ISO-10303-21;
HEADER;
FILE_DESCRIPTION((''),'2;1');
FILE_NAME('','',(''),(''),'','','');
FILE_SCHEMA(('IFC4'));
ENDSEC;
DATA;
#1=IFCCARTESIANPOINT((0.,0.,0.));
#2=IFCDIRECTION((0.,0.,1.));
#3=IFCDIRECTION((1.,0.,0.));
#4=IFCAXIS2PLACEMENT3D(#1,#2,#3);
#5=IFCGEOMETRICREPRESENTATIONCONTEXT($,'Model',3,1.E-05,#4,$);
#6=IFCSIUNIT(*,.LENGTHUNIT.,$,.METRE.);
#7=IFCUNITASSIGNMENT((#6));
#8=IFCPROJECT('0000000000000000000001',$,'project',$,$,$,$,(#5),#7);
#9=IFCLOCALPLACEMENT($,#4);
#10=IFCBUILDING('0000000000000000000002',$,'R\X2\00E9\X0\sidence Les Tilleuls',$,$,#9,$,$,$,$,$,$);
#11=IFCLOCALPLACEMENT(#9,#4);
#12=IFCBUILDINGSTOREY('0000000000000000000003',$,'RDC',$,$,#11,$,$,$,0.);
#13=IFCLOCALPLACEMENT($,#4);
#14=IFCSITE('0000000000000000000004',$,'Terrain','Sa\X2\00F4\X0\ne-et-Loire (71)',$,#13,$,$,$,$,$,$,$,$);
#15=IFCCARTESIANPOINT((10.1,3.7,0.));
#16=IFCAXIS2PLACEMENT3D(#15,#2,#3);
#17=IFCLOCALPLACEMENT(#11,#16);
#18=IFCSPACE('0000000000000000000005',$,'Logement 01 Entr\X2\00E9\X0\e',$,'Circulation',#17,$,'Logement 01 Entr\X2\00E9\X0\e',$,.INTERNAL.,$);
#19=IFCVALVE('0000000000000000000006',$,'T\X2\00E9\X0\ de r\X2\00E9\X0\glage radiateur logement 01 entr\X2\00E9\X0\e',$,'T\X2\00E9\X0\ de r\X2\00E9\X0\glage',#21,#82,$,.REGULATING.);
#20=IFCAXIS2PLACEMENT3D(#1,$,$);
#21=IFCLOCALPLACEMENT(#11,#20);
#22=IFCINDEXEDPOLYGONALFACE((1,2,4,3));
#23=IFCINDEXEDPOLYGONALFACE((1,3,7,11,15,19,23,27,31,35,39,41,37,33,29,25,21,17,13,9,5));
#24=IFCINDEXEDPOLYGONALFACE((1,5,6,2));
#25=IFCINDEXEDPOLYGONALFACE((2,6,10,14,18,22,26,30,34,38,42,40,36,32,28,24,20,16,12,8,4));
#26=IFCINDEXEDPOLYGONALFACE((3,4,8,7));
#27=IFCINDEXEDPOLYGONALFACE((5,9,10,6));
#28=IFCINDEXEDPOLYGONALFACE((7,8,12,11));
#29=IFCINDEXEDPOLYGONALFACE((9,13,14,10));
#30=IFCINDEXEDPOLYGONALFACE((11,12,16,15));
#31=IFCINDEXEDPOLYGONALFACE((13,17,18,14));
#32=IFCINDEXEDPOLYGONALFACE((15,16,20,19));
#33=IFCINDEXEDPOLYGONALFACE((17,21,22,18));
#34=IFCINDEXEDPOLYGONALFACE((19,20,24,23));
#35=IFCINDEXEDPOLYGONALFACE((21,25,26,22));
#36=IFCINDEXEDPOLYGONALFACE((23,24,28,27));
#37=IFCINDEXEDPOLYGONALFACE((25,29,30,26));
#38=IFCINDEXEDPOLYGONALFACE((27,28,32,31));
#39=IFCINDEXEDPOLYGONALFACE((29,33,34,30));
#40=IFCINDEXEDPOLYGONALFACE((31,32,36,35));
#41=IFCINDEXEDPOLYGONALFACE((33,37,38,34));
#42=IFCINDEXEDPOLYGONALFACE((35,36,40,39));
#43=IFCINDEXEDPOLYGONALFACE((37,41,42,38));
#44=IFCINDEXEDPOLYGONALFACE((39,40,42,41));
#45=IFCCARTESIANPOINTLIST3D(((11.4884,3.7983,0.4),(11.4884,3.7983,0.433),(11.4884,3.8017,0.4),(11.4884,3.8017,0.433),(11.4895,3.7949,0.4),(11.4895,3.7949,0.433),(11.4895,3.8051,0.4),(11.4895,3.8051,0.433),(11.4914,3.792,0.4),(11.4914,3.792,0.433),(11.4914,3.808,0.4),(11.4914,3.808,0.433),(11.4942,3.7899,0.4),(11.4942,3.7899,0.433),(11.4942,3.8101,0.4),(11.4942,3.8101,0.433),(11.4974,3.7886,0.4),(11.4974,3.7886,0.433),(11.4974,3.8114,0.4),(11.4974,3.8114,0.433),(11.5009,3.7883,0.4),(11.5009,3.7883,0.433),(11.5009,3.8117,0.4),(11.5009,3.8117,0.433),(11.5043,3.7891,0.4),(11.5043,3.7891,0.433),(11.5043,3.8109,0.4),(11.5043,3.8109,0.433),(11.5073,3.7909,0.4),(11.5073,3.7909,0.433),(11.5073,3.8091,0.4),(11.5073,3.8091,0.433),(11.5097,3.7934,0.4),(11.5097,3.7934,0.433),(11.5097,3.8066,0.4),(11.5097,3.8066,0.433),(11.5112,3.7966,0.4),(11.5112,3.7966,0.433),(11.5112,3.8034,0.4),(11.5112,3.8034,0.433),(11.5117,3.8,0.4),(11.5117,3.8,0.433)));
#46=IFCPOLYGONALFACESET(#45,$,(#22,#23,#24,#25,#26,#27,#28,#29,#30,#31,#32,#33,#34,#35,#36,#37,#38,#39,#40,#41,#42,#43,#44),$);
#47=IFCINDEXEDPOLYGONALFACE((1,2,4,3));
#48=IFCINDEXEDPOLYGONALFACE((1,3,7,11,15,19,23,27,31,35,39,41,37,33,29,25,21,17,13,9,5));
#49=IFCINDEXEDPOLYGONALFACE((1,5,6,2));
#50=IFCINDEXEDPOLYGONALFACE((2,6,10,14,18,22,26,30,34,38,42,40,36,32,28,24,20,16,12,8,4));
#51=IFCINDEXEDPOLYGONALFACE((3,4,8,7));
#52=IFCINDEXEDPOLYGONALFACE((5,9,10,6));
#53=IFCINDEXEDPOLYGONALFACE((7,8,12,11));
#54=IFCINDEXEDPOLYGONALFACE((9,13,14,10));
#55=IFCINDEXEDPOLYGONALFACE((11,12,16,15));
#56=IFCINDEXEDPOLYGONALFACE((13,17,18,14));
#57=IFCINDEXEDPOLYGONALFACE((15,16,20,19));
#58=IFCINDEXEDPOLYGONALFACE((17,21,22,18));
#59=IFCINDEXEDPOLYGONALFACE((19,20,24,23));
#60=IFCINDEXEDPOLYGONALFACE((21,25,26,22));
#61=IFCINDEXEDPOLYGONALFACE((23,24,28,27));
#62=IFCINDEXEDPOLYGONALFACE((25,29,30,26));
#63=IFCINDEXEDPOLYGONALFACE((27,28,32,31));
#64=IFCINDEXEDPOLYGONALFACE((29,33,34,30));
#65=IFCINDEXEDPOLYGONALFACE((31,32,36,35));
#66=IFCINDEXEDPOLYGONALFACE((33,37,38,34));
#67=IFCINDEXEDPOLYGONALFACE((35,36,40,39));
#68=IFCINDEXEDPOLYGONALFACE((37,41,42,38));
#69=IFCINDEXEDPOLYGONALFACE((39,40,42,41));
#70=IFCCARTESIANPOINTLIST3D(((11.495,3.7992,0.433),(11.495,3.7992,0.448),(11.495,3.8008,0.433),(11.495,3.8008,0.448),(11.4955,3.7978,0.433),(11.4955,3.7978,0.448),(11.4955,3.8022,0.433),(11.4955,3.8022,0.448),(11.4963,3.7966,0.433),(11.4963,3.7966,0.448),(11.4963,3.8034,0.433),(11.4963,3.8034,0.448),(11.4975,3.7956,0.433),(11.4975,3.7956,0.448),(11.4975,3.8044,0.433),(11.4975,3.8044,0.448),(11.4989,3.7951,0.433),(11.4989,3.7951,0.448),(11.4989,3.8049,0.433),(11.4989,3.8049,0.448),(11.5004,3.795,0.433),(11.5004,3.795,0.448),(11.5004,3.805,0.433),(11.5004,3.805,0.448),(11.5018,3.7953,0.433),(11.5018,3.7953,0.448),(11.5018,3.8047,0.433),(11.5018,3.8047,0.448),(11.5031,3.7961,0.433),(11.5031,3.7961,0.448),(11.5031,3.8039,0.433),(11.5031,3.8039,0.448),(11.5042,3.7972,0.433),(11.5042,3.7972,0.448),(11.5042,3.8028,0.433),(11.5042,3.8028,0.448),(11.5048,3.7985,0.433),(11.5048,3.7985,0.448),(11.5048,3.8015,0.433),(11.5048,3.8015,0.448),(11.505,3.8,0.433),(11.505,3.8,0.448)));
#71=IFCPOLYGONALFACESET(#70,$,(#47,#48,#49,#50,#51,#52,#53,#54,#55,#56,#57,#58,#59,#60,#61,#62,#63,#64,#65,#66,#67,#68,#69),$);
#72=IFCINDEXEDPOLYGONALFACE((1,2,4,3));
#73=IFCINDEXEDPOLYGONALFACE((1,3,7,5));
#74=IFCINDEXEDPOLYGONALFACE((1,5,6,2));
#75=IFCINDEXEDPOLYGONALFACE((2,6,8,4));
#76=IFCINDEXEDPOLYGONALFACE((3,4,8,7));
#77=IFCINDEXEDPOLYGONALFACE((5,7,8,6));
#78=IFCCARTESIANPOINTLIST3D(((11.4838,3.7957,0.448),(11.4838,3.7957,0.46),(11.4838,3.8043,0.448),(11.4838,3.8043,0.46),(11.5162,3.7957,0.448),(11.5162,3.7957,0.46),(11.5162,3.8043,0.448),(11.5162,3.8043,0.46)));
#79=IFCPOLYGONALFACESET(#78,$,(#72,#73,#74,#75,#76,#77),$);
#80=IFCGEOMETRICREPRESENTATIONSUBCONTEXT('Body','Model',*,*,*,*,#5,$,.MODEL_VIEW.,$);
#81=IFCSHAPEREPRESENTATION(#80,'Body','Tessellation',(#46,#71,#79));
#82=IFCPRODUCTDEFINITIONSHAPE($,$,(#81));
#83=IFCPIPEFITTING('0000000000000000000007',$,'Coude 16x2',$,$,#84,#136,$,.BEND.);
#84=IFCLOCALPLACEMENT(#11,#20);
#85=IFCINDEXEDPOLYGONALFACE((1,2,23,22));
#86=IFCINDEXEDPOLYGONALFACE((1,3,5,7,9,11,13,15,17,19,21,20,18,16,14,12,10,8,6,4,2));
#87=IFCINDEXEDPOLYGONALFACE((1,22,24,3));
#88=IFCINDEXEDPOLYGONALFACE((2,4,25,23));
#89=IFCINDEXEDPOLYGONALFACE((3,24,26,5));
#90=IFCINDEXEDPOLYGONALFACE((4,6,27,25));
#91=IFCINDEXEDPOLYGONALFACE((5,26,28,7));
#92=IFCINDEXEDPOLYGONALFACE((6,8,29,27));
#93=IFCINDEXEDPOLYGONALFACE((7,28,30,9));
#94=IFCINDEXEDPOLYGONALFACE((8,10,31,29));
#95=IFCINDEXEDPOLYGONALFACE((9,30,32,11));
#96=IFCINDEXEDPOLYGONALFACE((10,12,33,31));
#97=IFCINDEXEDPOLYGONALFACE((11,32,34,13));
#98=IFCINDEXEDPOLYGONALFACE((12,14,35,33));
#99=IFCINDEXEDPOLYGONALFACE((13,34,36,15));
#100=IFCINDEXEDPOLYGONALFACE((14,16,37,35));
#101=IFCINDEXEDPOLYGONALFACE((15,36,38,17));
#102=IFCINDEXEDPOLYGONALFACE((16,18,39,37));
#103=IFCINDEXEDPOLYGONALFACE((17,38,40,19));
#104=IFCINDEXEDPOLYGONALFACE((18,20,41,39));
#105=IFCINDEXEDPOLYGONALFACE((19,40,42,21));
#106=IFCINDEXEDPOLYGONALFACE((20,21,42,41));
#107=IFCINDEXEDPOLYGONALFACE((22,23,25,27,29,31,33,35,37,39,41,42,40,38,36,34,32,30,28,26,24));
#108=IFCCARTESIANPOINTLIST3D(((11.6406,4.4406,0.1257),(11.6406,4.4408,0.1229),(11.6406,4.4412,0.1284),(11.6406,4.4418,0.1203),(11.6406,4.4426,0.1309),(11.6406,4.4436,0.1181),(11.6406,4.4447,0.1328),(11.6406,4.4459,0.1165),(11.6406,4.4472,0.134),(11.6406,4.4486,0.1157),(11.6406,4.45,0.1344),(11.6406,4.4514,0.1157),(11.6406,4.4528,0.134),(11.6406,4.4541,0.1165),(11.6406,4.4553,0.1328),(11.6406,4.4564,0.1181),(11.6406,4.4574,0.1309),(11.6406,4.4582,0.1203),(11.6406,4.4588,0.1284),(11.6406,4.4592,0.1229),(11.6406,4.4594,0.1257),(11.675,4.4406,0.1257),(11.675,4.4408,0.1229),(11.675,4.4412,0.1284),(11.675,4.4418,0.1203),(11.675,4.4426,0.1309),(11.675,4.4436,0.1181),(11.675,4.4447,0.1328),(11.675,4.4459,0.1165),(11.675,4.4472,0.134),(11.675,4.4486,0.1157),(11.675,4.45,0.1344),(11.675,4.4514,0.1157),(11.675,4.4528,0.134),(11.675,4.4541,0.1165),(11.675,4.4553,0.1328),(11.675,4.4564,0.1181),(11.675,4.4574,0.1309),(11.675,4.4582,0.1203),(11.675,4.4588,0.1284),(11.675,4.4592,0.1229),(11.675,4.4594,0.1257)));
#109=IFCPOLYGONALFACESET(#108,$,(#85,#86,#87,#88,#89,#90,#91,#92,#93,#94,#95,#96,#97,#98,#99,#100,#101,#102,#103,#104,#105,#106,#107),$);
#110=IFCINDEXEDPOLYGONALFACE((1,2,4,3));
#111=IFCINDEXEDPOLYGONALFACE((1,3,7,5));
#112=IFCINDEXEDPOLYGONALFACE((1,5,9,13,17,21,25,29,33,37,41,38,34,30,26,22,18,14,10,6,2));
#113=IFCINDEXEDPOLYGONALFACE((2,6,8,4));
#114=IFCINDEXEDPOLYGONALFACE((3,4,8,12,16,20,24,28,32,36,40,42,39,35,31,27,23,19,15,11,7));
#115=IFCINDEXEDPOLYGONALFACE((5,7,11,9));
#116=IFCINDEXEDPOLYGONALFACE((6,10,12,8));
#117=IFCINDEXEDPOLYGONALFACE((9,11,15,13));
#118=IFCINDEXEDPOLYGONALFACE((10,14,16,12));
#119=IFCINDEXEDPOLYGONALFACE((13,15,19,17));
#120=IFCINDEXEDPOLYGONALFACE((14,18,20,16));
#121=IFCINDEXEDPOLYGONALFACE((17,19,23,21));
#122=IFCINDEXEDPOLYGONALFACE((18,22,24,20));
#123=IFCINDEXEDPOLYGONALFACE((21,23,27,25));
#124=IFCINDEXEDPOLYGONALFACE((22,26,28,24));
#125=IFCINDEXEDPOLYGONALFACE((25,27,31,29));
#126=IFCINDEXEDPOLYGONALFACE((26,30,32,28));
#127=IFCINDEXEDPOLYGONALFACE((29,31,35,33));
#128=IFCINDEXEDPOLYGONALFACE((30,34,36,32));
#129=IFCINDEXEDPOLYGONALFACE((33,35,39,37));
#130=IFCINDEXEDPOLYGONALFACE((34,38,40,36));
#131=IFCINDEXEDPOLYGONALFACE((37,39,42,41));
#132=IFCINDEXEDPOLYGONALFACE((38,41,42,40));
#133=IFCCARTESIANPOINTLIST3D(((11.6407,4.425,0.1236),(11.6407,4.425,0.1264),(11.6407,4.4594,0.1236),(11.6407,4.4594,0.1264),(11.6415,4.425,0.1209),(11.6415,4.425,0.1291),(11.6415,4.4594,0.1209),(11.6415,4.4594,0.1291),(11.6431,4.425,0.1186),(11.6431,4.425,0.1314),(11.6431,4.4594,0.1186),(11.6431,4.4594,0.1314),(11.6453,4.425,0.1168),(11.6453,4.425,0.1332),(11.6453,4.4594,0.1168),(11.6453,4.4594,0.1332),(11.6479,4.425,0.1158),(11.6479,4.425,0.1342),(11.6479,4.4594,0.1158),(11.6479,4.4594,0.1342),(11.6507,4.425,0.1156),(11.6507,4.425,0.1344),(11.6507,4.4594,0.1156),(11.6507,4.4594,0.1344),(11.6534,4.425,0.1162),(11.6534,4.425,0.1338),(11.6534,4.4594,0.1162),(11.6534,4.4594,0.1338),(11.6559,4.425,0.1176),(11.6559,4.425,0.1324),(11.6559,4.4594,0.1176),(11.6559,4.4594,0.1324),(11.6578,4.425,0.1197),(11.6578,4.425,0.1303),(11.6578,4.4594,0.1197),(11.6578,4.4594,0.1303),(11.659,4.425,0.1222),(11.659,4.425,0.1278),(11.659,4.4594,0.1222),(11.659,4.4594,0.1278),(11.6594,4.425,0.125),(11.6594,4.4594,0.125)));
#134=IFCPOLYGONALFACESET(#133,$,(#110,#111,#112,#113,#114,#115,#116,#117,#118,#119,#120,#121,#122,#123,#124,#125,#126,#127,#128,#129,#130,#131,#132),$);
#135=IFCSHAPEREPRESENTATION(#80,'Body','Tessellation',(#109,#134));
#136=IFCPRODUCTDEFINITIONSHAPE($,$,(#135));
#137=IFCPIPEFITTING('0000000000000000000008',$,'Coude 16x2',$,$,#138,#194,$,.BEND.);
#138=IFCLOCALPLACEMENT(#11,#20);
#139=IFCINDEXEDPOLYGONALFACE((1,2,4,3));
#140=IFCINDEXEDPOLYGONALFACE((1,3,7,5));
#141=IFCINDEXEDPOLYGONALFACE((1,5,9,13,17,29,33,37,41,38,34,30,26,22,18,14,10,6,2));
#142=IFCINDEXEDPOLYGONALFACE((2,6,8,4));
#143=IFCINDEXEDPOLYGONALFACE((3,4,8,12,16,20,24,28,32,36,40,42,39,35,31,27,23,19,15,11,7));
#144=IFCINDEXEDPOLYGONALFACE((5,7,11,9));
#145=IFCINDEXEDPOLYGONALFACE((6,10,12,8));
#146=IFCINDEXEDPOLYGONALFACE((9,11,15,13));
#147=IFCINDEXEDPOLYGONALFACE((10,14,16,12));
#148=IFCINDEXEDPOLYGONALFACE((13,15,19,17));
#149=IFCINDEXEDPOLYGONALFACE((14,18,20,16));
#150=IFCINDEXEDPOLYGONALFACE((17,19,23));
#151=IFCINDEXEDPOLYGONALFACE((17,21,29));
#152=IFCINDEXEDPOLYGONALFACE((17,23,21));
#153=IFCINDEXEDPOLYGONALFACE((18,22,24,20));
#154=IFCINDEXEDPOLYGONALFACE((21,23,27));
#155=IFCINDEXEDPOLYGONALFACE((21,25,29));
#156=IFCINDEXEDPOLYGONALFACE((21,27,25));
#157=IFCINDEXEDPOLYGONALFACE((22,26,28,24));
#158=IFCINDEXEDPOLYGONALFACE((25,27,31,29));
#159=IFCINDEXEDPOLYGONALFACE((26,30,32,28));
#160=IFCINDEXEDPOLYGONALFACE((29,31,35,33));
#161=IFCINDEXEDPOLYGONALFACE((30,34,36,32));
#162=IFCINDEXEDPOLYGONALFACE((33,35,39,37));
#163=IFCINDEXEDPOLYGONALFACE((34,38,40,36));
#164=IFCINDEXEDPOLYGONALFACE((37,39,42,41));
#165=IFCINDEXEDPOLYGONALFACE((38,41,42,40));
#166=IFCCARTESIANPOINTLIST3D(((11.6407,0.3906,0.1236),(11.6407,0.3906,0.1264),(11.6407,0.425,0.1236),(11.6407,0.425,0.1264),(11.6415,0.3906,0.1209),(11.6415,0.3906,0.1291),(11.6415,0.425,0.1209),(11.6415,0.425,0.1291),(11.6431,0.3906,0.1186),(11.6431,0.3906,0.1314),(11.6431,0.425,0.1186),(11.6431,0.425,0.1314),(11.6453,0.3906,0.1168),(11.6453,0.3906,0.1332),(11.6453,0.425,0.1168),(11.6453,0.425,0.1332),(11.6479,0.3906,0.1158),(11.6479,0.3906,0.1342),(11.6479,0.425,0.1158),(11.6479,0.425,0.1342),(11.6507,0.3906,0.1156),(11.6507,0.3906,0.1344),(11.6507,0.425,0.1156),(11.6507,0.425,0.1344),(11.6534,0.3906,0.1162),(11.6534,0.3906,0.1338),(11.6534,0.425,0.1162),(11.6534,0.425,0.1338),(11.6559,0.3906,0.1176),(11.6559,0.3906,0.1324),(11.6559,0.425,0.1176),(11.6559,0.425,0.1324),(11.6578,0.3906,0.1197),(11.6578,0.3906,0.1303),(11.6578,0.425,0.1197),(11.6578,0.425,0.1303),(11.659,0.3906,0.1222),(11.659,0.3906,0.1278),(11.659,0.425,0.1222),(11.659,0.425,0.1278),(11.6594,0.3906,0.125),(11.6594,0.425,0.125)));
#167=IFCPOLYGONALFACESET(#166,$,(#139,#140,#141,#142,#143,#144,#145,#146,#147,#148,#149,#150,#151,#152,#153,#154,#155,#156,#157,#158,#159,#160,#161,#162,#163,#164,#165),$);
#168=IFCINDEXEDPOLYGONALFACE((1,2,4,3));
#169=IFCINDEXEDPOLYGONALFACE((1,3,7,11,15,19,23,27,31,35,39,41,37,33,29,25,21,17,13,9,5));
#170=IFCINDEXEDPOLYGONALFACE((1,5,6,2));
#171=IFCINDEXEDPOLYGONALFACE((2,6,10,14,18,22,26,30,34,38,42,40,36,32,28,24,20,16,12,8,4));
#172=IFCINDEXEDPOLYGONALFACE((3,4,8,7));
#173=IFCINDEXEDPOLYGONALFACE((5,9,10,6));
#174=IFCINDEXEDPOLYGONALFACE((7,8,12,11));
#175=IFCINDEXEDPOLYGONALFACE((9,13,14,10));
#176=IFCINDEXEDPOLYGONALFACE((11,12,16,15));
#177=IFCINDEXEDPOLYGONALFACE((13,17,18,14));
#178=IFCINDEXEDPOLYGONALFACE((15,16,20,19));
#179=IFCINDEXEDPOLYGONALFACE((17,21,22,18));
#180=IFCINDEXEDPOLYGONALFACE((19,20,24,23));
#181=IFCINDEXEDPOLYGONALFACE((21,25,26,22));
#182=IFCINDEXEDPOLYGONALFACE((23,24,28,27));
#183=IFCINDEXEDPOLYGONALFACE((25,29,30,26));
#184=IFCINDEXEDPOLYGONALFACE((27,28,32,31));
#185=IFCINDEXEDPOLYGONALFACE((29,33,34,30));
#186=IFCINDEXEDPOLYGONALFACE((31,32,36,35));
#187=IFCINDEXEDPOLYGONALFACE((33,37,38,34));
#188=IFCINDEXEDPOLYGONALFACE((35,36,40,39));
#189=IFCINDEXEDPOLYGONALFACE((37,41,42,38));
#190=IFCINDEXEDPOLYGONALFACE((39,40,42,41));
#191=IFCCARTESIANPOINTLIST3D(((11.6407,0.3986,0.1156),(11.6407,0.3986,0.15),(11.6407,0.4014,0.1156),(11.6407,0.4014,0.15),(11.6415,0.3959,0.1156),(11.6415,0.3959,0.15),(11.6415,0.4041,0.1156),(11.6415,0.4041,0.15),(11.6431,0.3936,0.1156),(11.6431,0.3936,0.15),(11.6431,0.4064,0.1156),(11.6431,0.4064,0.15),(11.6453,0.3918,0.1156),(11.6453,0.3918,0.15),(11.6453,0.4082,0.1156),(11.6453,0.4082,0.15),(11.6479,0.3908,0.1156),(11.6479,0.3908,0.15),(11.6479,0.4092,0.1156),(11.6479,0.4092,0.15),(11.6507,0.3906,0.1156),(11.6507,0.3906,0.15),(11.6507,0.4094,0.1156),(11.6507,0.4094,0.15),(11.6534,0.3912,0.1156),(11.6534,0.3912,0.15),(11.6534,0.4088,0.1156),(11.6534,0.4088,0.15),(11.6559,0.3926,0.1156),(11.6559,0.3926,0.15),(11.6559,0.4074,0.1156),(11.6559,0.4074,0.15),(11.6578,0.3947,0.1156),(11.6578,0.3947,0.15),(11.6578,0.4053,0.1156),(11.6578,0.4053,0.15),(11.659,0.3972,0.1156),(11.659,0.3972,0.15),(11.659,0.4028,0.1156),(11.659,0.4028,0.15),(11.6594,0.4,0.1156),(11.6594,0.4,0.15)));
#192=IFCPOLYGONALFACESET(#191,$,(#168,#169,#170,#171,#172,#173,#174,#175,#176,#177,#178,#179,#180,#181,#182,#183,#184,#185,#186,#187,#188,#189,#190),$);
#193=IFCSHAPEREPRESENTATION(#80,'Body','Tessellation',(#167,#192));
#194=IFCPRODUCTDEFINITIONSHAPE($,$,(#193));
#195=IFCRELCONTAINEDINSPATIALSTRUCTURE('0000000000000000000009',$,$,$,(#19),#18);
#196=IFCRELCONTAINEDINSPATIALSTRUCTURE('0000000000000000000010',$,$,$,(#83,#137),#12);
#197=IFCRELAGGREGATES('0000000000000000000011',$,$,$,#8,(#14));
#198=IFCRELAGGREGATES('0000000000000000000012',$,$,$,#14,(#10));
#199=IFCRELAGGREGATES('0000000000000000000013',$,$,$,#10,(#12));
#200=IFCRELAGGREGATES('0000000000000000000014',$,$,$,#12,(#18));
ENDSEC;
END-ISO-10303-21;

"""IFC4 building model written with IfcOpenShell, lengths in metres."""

from ifc_helpers import new_model, si_unit, frame, frame_2d, origin_with_axes, place, context, subcontext, project, spatial, rectangle, circle, extrude, element, save


model = new_model("IFC4")

# Units and contexts
model_context = context("Model", 3, precision=1e-05, world=origin_with_axes())
body_context = subcontext(model_context, "Body", "Model", "MODEL_VIEW")
ifc_project = project(units=[si_unit("LENGTHUNIT", "METRE")], contexts=[model_context])

# Site, building, storey
site_placement = place(None, origin_with_axes())
site = spatial("IfcSite", under=ifc_project, at=site_placement, Name="Terrain", Description="Saône-et-Loire (71)")
building_placement = place(None, origin_with_axes())
building = spatial("IfcBuilding", under=site, at=building_placement, Name="Résidence Les Tilleuls")
storey_placement = place(building_placement, origin_with_axes())
storey = spatial("IfcBuildingStorey", under=building, at=storey_placement, Name="RDC", Elevation=0.0)

# Shared definitions
space_1_placement = place(storey_placement, frame((10.1, 3.7, 0.0), z_axis=(0.0, 0.0, 1.0), x_axis=(1.0, 0.0, 0.0)))
space_1 = spatial("IfcSpace", under=storey, at=space_1_placement, Name="Logement 01 Entrée", ObjectType="Circulation", LongName="Logement 01 Entrée", PredefinedType="INTERNAL")

# Valve
valve_1_placement = place(space_1_placement, frame((1.4, 0.1, 0.4), z_axis=(0.0, 0.0, 1.0), x_axis=(1.0, 0.0, 0.0)))
element("IfcValve", 1, at=valve_1_placement, inside=space_1, Name="Té de réglage radiateur logement 01 entrée", ObjectType="Té de réglage", PredefinedType="REGULATING", context=body_context, shape_type="SweptSolid", body=[
    extrude(circle(Radius=0.0117), origin_with_axes(), (0.0, 0.0, 1.0), 0.033),
    extrude(circle(Radius=0.005), frame((0.0, 0.0, 0.033), z_axis=(0.0, 0.0, 1.0), x_axis=(1.0, 0.0, 0.0)), (0.0, 0.0, 1.0), 0.015),
    extrude(rectangle(XDim=0.0324, YDim=0.0086, at=frame_2d((0.0162, 0.0043))), frame((-0.0162, -0.0043, 0.048), z_axis=(0.0, 0.0, 1.0), x_axis=(1.0, 0.0, 0.0)), (0.0, 0.0, 1.0), 0.012),
])

# Pipe fittings
pipe_fitting_1_placement = place(storey_placement, frame((11.65, 4.45, 0.125), z_axis=(0.0, 0.0, 1.0), x_axis=(1.0, 0.0, 0.0)))
element("IfcPipeFitting", 2, at=pipe_fitting_1_placement, inside=storey, Name="Coude 16x2", PredefinedType="BEND", context=body_context, shape_type="SweptSolid", body=[
    extrude(circle(Radius=0.0094), frame((-0.0094, 0.0, 0.0), z_axis=(1.0, 0.0, 0.0), x_axis=(0.0, 0.0, 1.0)), (0.0, 0.0, 1.0), 0.0344),
    extrude(circle(Radius=0.0094), frame((0.0, 0.0094, 0.0), z_axis=(0.0, -1.0, 0.0), x_axis=(1.0, 0.0, 0.0)), (0.0, 0.0, 1.0), 0.0344),
])
pipe_fitting_2_placement = place(storey_placement, frame((11.65, 0.4, 0.125), z_axis=(0.0, 0.0, 1.0), x_axis=(1.0, 0.0, 0.0)))
element("IfcPipeFitting", 3, at=pipe_fitting_2_placement, inside=storey, Name="Coude 16x2", PredefinedType="BEND", context=body_context, shape_type="SweptSolid", body=[
    extrude(circle(Radius=0.0094), frame((0.0, -0.0094, 0.0), z_axis=(0.0, 1.0, 0.0), x_axis=(1.0, 0.0, 0.0)), (0.0, 0.0, 1.0), 0.0344),
    extrude(circle(Radius=0.0094), frame((0.0, 0.0, -0.0094), z_axis=(0.0, 0.0, 1.0), x_axis=(1.0, 0.0, 0.0)), (0.0, 0.0, 1.0), 0.0344),
])

save(model, "model.ifc")
